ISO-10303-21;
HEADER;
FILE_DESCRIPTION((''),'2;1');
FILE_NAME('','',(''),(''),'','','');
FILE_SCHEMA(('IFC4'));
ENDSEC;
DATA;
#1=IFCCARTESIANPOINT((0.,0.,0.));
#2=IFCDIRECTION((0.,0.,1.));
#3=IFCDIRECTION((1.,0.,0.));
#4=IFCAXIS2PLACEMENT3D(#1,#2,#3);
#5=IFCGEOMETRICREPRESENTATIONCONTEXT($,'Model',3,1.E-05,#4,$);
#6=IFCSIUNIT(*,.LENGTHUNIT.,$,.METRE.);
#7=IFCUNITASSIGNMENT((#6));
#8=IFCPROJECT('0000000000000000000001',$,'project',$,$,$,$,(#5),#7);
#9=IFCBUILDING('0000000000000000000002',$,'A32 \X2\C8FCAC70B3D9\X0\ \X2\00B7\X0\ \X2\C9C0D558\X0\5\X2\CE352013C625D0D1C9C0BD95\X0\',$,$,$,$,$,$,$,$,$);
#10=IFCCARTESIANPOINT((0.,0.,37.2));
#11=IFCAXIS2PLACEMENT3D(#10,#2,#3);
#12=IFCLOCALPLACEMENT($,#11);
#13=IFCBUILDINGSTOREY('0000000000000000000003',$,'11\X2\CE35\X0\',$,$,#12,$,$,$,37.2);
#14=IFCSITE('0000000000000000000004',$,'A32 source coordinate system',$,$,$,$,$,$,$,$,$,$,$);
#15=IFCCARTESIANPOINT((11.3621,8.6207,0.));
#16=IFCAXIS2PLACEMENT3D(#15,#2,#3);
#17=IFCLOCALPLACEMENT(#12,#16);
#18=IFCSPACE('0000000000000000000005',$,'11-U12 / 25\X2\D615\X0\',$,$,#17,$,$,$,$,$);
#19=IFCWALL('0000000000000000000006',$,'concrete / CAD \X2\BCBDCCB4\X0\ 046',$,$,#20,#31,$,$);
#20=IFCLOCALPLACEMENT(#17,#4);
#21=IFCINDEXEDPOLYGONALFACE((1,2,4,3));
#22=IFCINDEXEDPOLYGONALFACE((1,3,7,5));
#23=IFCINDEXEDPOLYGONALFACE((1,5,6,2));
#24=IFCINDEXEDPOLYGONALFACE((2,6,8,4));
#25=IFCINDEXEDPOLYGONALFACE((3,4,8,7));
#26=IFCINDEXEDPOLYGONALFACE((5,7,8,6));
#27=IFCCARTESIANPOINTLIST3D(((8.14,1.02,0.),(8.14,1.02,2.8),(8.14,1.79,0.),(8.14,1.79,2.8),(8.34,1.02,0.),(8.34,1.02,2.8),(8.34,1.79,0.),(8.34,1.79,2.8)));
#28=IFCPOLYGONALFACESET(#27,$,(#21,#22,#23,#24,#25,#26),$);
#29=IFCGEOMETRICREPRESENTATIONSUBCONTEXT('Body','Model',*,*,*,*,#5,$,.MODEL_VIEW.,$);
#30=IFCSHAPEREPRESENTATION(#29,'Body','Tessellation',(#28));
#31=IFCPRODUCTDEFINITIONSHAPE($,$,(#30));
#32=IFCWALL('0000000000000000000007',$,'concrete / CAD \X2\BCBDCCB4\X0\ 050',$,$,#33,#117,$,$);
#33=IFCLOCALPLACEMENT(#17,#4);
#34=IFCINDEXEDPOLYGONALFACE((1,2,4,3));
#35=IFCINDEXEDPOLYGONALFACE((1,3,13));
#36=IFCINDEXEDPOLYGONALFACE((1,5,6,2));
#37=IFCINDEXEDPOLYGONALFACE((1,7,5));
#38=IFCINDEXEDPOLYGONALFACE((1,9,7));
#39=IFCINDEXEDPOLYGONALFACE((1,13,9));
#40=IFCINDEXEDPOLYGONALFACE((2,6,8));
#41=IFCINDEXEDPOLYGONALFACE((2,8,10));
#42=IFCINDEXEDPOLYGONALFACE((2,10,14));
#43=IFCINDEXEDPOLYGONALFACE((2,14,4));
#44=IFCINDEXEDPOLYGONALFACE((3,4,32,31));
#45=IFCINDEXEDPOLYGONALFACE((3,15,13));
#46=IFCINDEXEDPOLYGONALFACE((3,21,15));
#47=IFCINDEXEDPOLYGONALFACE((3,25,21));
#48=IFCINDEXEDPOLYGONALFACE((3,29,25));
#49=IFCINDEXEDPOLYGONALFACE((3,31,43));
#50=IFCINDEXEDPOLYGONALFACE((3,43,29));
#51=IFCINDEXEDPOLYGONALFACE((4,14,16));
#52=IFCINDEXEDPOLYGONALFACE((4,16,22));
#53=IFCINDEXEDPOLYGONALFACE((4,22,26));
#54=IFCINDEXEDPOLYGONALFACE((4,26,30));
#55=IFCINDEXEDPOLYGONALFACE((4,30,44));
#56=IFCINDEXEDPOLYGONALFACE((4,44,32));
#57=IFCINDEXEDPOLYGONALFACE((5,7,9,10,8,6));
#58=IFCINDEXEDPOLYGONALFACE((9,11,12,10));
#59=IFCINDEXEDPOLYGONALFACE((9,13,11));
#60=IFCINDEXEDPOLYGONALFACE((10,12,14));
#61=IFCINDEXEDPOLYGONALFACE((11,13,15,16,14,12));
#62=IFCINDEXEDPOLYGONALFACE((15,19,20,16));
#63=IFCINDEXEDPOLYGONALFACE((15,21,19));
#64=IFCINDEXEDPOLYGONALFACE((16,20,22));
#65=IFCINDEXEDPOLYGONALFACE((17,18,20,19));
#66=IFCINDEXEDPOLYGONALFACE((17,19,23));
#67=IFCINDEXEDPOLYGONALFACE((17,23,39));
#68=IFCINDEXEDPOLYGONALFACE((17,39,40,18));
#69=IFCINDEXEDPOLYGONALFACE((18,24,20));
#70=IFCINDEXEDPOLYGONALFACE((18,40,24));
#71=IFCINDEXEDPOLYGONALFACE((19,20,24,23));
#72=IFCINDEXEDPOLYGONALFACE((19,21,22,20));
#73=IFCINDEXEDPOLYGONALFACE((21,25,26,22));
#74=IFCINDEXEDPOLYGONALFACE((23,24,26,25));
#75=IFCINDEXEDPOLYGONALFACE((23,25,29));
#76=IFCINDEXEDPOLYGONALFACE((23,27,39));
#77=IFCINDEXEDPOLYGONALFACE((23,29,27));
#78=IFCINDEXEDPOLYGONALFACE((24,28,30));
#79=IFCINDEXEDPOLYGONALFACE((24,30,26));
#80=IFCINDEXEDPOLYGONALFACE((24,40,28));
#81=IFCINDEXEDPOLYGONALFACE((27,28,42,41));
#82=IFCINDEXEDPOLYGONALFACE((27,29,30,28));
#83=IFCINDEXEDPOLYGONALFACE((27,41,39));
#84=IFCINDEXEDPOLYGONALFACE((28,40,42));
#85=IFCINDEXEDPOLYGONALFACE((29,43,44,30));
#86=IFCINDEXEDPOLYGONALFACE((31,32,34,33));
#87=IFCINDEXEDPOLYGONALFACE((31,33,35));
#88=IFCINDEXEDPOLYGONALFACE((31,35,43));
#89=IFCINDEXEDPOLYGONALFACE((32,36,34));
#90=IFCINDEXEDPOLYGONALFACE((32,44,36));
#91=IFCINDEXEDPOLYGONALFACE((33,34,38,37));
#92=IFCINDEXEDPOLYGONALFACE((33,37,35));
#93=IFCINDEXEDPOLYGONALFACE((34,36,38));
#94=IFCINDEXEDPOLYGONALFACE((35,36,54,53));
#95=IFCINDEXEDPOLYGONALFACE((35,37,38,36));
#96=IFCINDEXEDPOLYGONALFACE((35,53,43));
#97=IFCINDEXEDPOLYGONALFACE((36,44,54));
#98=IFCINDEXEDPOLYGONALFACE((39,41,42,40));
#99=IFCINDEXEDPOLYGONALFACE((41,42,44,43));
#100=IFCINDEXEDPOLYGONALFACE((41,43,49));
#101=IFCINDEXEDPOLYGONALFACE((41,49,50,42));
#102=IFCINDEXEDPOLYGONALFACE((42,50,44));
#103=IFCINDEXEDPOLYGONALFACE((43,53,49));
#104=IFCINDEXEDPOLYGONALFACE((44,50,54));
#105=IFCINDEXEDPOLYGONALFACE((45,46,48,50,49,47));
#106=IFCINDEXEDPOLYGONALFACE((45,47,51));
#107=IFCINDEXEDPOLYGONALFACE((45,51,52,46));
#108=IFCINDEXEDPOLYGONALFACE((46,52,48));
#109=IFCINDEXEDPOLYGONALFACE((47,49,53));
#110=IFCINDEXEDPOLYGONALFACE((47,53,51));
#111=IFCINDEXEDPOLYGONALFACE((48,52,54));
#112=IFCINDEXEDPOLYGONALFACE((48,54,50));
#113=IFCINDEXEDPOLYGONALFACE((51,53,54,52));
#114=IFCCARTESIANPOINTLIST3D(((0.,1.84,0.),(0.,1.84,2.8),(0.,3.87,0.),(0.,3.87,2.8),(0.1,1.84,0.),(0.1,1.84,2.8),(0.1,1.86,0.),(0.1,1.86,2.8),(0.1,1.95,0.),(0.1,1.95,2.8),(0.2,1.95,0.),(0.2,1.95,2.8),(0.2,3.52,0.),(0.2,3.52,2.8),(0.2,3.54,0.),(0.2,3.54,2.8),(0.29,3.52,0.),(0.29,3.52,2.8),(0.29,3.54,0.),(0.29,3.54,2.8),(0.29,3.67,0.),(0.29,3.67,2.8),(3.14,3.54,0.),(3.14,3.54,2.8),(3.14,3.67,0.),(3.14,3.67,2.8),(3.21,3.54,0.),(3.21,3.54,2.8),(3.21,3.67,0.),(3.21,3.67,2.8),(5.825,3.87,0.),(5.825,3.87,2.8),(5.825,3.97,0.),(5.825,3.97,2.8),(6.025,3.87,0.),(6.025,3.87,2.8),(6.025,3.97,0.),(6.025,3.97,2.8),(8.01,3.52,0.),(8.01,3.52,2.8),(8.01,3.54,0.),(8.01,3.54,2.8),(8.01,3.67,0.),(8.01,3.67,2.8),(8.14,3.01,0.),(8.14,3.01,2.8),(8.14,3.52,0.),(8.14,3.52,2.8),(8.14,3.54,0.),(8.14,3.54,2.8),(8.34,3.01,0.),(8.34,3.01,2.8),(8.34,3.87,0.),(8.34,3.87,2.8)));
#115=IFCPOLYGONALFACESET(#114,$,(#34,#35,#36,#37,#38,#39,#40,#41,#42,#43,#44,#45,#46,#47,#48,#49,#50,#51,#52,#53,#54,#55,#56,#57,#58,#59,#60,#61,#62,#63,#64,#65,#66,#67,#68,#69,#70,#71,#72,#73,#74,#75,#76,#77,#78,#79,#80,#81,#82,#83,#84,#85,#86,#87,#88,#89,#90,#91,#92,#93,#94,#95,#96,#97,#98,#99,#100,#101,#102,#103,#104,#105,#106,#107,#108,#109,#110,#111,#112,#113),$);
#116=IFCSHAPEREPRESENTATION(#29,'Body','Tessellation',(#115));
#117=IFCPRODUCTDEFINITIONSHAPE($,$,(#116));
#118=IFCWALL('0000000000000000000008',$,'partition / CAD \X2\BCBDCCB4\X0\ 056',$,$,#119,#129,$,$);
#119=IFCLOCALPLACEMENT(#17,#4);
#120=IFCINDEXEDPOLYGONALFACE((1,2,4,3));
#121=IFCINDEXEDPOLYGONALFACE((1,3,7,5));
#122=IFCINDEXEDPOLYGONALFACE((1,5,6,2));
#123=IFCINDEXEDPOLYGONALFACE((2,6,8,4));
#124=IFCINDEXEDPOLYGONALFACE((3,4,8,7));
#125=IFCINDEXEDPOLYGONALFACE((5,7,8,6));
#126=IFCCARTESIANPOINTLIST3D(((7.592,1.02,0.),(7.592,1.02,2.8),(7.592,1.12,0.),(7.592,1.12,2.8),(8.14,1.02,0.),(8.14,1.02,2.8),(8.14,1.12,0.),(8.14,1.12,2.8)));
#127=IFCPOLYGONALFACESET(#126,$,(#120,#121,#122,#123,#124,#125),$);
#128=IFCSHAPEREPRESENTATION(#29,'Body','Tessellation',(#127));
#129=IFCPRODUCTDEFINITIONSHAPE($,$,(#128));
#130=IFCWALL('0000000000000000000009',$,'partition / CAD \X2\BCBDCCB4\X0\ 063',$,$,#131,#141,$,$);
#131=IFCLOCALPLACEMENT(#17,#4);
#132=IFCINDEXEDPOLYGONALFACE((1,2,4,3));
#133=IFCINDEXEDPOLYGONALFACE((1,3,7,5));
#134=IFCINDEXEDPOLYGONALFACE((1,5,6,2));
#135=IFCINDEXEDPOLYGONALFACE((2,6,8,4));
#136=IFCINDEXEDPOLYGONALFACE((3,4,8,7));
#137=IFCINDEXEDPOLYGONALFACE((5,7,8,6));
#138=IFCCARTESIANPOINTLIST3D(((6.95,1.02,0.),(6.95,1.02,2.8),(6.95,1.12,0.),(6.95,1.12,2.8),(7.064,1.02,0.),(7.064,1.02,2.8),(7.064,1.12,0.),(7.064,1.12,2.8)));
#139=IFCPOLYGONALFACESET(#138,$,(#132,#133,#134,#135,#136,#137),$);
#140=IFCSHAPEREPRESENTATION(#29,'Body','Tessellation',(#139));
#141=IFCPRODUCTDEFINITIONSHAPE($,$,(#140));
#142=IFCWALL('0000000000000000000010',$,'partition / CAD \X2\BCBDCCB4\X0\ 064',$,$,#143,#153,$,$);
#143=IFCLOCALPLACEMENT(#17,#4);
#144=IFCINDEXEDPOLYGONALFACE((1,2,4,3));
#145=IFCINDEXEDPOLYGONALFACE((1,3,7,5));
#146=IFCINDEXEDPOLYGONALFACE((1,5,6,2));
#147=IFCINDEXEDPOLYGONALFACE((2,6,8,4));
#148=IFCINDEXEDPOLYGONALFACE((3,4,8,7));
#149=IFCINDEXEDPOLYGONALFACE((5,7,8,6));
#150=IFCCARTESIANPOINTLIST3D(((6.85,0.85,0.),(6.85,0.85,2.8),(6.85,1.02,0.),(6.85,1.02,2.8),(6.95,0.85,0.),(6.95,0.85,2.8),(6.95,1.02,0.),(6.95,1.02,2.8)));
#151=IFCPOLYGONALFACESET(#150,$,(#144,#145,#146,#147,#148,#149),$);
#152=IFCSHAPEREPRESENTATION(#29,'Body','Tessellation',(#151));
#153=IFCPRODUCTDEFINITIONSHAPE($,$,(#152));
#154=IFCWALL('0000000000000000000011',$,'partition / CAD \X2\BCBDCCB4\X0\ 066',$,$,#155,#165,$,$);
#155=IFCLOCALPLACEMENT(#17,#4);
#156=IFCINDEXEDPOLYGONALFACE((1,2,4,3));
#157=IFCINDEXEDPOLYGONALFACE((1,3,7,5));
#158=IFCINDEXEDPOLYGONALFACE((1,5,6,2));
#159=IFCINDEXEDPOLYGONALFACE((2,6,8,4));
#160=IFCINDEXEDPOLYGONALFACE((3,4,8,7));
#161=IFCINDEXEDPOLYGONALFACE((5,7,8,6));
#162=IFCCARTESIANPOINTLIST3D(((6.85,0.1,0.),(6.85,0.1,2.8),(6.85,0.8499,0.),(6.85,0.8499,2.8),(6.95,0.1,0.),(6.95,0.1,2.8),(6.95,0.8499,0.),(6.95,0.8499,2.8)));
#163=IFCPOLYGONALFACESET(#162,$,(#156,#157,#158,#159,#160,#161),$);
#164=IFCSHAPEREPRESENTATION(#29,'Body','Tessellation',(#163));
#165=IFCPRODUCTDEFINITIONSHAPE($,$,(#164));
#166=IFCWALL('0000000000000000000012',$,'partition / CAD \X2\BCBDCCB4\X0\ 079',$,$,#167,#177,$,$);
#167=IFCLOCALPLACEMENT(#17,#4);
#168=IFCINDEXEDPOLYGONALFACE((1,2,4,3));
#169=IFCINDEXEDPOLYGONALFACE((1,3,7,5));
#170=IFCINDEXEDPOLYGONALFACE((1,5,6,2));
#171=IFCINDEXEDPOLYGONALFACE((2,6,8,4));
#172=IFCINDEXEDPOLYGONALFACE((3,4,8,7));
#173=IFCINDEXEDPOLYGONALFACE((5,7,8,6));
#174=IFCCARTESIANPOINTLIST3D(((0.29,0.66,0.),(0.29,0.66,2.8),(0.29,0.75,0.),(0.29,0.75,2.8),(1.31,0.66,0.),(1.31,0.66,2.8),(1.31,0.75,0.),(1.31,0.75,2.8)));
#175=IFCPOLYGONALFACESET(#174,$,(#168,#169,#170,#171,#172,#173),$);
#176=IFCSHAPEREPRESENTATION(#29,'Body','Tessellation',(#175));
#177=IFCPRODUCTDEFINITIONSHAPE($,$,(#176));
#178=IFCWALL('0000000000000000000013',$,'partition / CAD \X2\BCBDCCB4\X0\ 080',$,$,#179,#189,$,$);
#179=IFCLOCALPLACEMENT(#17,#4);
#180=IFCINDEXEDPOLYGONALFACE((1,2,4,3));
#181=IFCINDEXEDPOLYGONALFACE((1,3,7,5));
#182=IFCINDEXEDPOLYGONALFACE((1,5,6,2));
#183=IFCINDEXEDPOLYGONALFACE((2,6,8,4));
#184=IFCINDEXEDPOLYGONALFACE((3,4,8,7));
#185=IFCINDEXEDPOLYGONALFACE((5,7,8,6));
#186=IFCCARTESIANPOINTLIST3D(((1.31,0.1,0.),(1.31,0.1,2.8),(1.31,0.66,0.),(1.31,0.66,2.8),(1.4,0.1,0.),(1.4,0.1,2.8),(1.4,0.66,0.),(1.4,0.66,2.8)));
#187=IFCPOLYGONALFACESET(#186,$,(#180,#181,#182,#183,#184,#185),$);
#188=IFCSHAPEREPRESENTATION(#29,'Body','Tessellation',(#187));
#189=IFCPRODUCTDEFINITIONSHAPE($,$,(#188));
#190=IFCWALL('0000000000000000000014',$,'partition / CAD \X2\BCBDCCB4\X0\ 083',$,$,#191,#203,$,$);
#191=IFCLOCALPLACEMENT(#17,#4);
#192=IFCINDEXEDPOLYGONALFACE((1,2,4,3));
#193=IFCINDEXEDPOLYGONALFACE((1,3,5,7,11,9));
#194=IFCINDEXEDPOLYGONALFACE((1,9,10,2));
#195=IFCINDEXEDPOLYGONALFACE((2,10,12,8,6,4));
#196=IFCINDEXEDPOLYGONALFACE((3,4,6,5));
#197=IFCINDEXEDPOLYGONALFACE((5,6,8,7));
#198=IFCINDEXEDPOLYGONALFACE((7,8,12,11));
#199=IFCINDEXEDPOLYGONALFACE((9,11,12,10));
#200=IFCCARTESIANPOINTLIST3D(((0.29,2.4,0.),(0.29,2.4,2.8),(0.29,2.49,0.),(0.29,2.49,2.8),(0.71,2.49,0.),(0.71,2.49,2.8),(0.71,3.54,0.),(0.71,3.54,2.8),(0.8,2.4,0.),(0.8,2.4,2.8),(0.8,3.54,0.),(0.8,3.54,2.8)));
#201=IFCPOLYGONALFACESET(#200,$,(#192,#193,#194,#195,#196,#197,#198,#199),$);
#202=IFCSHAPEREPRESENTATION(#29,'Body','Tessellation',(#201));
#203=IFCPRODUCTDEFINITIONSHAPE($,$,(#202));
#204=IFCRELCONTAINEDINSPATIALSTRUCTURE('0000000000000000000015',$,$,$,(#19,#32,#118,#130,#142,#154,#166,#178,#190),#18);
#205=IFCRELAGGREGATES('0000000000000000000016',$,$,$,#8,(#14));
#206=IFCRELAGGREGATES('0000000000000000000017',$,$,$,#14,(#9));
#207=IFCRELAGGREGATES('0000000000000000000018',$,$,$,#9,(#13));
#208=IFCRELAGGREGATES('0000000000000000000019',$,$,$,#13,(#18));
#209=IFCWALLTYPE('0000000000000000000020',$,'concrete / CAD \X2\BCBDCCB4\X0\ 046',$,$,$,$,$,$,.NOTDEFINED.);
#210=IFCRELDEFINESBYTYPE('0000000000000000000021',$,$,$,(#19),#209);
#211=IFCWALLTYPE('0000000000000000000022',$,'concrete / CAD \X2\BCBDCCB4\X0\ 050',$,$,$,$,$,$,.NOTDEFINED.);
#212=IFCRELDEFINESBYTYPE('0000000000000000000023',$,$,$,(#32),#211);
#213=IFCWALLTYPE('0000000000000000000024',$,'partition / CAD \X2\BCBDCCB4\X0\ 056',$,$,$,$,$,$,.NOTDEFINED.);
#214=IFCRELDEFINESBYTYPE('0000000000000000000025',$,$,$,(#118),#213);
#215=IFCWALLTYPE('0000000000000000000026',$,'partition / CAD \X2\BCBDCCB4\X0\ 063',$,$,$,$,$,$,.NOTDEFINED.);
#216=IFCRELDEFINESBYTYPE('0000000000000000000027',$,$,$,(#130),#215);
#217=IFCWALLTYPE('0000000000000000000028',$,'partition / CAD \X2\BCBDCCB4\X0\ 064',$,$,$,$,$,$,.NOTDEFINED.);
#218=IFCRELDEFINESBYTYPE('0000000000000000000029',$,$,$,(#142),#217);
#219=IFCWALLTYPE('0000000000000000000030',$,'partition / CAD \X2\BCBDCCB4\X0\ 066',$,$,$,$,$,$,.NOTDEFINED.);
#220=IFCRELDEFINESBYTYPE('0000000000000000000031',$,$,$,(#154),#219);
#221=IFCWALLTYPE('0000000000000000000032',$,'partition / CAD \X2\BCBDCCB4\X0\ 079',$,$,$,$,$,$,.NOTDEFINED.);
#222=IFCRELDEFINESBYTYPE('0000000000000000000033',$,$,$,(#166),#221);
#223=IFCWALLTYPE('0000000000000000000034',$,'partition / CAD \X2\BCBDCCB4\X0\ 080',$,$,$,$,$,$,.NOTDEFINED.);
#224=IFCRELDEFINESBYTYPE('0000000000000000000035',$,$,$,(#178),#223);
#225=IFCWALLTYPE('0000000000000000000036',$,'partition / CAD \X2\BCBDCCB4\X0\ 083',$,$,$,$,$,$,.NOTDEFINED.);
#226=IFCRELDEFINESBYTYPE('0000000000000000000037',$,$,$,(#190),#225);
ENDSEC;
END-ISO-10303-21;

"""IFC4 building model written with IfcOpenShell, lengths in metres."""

from ifc_helpers import new_model, si_unit, frame, origin, origin_with_axes, place, context, subcontext, project, spatial, polyline, outline, extrude, source, transform, mapped, type_object, type_shapes, element, save


model = new_model("IFC4")

# Units and contexts
model_context = context("Model", 3, precision=1e-05, world=origin_with_axes())
body_context = subcontext(model_context, "Body", "Model", "MODEL_VIEW")
ifc_project = project(units=[si_unit("LENGTHUNIT", "METRE")], contexts=[model_context])

# Site, building, storey, space
site = spatial("IfcSite", under=ifc_project, Name="A32 source coordinate system")
building = spatial("IfcBuilding", under=site, Name="A32 주거동 · 지하5층–옥탑지붕")
storey_placement = place(None, frame((0.0, 0.0, 37.2), z_axis=(0.0, 0.0, 1.0), x_axis=(1.0, 0.0, 0.0)))
storey = spatial("IfcBuildingStorey", under=building, at=storey_placement, Name="11층", Elevation=37.2)
space_1_placement = place(storey_placement, frame((11.3621, 8.6207, 0.0), z_axis=(0.0, 0.0, 1.0), x_axis=(1.0, 0.0, 0.0)))
space_1 = spatial("IfcSpace", under=storey, at=space_1_placement, Name="11-U12 / 25형")

# Walls
wall_type_1 = type_object("IfcWallType", Name="concrete / CAD 벽체 046", PredefinedType="NOTDEFINED")
shared_shape_1 = source(origin(), body_context, "Body", "SweptSolid", [
    extrude(outline(polyline([(8.14, 1.02), (8.14, 1.79), (8.34, 1.79), (8.34, 1.02), (8.14, 1.02)])), origin(), (0.0, 0.0, 1.0), 2.8),
])
type_shapes(wall_type_1, [shared_shape_1])
wall_1_placement = place(space_1_placement, origin_with_axes())
element("IfcWall", 1, at=wall_1_placement, inside=space_1, type_object=wall_type_1, Name="concrete / CAD 벽체 046", context=body_context, shape_type="MappedRepresentation", body=[
    mapped(shared_shape_1, transform((0.0, 0.0, 0.0), scale=1.0)),
])
wall_type_2 = type_object("IfcWallType", Name="concrete / CAD 벽체 050", PredefinedType="NOTDEFINED")
shared_shape_2 = source(origin(), body_context, "Body", "SweptSolid", [
    extrude(outline(polyline([(8.01, 3.52), (0.29, 3.52), (0.29, 3.54), (0.2, 3.54), (0.2, 3.52), (0.2, 1.95), (0.1, 1.95), (0.1, 1.86), (0.1, 1.84), (0.0, 1.84), (0.0, 3.87), (5.825, 3.87), (5.825, 3.97), (6.025, 3.97), (6.025, 3.87), (8.34, 3.87), (8.34, 3.01), (8.14, 3.01), (8.14, 3.52), (8.14, 3.54), (8.01, 3.54), (8.01, 3.52)]), holes=[polyline([(3.14, 3.54), (3.14, 3.67), (0.29, 3.67), (0.29, 3.54), (3.14, 3.54)]), polyline([(8.01, 3.67), (3.21, 3.67), (3.21, 3.54), (8.01, 3.54), (8.01, 3.67)])]), origin(), (0.0, 0.0, 1.0), 2.8),
])
type_shapes(wall_type_2, [shared_shape_2])
wall_2_placement = place(space_1_placement, origin_with_axes())
element("IfcWall", 2, at=wall_2_placement, inside=space_1, type_object=wall_type_2, Name="concrete / CAD 벽체 050", context=body_context, shape_type="MappedRepresentation", body=[
    mapped(shared_shape_2, transform((0.0, 0.0, 0.0), scale=1.0)),
])
wall_type_3 = type_object("IfcWallType", Name="partition / CAD 벽체 056", PredefinedType="NOTDEFINED")
shared_shape_3 = source(origin(), body_context, "Body", "SweptSolid", [
    extrude(outline(polyline([(7.592, 1.12), (8.14, 1.12), (8.14, 1.02), (7.592, 1.02), (7.592, 1.12)])), origin(), (0.0, 0.0, 1.0), 2.8),
])
type_shapes(wall_type_3, [shared_shape_3])
wall_3_placement = place(space_1_placement, origin_with_axes())
element("IfcWall", 3, at=wall_3_placement, inside=space_1, type_object=wall_type_3, Name="partition / CAD 벽체 056", context=body_context, shape_type="MappedRepresentation", body=[
    mapped(shared_shape_3, transform((0.0, 0.0, 0.0), scale=1.0)),
])
wall_type_4 = type_object("IfcWallType", Name="partition / CAD 벽체 063", PredefinedType="NOTDEFINED")
shared_shape_4 = source(origin(), body_context, "Body", "SweptSolid", [
    extrude(outline(polyline([(6.95, 1.12), (7.064, 1.12), (7.064, 1.02), (6.95, 1.02), (6.95, 1.12)])), origin(), (0.0, 0.0, 1.0), 2.8),
])
type_shapes(wall_type_4, [shared_shape_4])
wall_4_placement = place(space_1_placement, origin_with_axes())
element("IfcWall", 4, at=wall_4_placement, inside=space_1, type_object=wall_type_4, Name="partition / CAD 벽체 063", context=body_context, shape_type="MappedRepresentation", body=[
    mapped(shared_shape_4, transform((0.0, 0.0, 0.0), scale=1.0)),
])
wall_type_5 = type_object("IfcWallType", Name="partition / CAD 벽체 064", PredefinedType="NOTDEFINED")
shared_shape_5 = source(origin(), body_context, "Body", "SweptSolid", [
    extrude(outline(polyline([(6.95, 0.85), (6.85, 0.85), (6.85, 1.02), (6.95, 1.02), (6.95, 0.85)])), origin(), (0.0, 0.0, 1.0), 2.8),
])
type_shapes(wall_type_5, [shared_shape_5])
wall_5_placement = place(space_1_placement, origin_with_axes())
element("IfcWall", 5, at=wall_5_placement, inside=space_1, type_object=wall_type_5, Name="partition / CAD 벽체 064", context=body_context, shape_type="MappedRepresentation", body=[
    mapped(shared_shape_5, transform((0.0, 0.0, 0.0), scale=1.0)),
])
wall_type_6 = type_object("IfcWallType", Name="partition / CAD 벽체 066", PredefinedType="NOTDEFINED")
shared_shape_6 = source(origin(), body_context, "Body", "SweptSolid", [
    extrude(outline(polyline([(6.85, 0.8499), (6.95, 0.8499), (6.95, 0.1), (6.85, 0.1), (6.85, 0.8499)])), origin(), (0.0, 0.0, 1.0), 2.8),
])
type_shapes(wall_type_6, [shared_shape_6])
wall_6_placement = place(space_1_placement, origin_with_axes())
element("IfcWall", 6, at=wall_6_placement, inside=space_1, type_object=wall_type_6, Name="partition / CAD 벽체 066", context=body_context, shape_type="MappedRepresentation", body=[
    mapped(shared_shape_6, transform((0.0, 0.0, 0.0), scale=1.0)),
])
wall_type_7 = type_object("IfcWallType", Name="partition / CAD 벽체 079", PredefinedType="NOTDEFINED")
shared_shape_7 = source(origin(), body_context, "Body", "SweptSolid", [
    extrude(outline(polyline([(0.29, 0.75), (1.31, 0.75), (1.31, 0.66), (0.29, 0.66), (0.29, 0.75)])), origin(), (0.0, 0.0, 1.0), 2.8),
])
type_shapes(wall_type_7, [shared_shape_7])
wall_7_placement = place(space_1_placement, origin_with_axes())
element("IfcWall", 7, at=wall_7_placement, inside=space_1, type_object=wall_type_7, Name="partition / CAD 벽체 079", context=body_context, shape_type="MappedRepresentation", body=[
    mapped(shared_shape_7, transform((0.0, 0.0, 0.0), scale=1.0)),
])
wall_type_8 = type_object("IfcWallType", Name="partition / CAD 벽체 080", PredefinedType="NOTDEFINED")
shared_shape_8 = source(origin(), body_context, "Body", "SweptSolid", [
    extrude(outline(polyline([(1.4, 0.66), (1.4, 0.1), (1.31, 0.1), (1.31, 0.66), (1.4, 0.66)])), origin(), (0.0, 0.0, 1.0), 2.8),
])
type_shapes(wall_type_8, [shared_shape_8])
wall_8_placement = place(space_1_placement, origin_with_axes())
element("IfcWall", 8, at=wall_8_placement, inside=space_1, type_object=wall_type_8, Name="partition / CAD 벽체 080", context=body_context, shape_type="MappedRepresentation", body=[
    mapped(shared_shape_8, transform((0.0, 0.0, 0.0), scale=1.0)),
])
wall_type_9 = type_object("IfcWallType", Name="partition / CAD 벽체 083", PredefinedType="NOTDEFINED")
shared_shape_9 = source(origin(), body_context, "Body", "SweptSolid", [
    extrude(outline(polyline([(0.71, 2.49), (0.71, 3.54), (0.8, 3.54), (0.8, 2.4), (0.29, 2.4), (0.29, 2.49), (0.71, 2.49)])), origin(), (0.0, 0.0, 1.0), 2.8),
])
type_shapes(wall_type_9, [shared_shape_9])
wall_9_placement = place(space_1_placement, origin_with_axes())
element("IfcWall", 9, at=wall_9_placement, inside=space_1, type_object=wall_type_9, Name="partition / CAD 벽체 083", context=body_context, shape_type="MappedRepresentation", body=[
    mapped(shared_shape_9, transform((0.0, 0.0, 0.0), scale=1.0)),
])

save(model, "model.ifc")
